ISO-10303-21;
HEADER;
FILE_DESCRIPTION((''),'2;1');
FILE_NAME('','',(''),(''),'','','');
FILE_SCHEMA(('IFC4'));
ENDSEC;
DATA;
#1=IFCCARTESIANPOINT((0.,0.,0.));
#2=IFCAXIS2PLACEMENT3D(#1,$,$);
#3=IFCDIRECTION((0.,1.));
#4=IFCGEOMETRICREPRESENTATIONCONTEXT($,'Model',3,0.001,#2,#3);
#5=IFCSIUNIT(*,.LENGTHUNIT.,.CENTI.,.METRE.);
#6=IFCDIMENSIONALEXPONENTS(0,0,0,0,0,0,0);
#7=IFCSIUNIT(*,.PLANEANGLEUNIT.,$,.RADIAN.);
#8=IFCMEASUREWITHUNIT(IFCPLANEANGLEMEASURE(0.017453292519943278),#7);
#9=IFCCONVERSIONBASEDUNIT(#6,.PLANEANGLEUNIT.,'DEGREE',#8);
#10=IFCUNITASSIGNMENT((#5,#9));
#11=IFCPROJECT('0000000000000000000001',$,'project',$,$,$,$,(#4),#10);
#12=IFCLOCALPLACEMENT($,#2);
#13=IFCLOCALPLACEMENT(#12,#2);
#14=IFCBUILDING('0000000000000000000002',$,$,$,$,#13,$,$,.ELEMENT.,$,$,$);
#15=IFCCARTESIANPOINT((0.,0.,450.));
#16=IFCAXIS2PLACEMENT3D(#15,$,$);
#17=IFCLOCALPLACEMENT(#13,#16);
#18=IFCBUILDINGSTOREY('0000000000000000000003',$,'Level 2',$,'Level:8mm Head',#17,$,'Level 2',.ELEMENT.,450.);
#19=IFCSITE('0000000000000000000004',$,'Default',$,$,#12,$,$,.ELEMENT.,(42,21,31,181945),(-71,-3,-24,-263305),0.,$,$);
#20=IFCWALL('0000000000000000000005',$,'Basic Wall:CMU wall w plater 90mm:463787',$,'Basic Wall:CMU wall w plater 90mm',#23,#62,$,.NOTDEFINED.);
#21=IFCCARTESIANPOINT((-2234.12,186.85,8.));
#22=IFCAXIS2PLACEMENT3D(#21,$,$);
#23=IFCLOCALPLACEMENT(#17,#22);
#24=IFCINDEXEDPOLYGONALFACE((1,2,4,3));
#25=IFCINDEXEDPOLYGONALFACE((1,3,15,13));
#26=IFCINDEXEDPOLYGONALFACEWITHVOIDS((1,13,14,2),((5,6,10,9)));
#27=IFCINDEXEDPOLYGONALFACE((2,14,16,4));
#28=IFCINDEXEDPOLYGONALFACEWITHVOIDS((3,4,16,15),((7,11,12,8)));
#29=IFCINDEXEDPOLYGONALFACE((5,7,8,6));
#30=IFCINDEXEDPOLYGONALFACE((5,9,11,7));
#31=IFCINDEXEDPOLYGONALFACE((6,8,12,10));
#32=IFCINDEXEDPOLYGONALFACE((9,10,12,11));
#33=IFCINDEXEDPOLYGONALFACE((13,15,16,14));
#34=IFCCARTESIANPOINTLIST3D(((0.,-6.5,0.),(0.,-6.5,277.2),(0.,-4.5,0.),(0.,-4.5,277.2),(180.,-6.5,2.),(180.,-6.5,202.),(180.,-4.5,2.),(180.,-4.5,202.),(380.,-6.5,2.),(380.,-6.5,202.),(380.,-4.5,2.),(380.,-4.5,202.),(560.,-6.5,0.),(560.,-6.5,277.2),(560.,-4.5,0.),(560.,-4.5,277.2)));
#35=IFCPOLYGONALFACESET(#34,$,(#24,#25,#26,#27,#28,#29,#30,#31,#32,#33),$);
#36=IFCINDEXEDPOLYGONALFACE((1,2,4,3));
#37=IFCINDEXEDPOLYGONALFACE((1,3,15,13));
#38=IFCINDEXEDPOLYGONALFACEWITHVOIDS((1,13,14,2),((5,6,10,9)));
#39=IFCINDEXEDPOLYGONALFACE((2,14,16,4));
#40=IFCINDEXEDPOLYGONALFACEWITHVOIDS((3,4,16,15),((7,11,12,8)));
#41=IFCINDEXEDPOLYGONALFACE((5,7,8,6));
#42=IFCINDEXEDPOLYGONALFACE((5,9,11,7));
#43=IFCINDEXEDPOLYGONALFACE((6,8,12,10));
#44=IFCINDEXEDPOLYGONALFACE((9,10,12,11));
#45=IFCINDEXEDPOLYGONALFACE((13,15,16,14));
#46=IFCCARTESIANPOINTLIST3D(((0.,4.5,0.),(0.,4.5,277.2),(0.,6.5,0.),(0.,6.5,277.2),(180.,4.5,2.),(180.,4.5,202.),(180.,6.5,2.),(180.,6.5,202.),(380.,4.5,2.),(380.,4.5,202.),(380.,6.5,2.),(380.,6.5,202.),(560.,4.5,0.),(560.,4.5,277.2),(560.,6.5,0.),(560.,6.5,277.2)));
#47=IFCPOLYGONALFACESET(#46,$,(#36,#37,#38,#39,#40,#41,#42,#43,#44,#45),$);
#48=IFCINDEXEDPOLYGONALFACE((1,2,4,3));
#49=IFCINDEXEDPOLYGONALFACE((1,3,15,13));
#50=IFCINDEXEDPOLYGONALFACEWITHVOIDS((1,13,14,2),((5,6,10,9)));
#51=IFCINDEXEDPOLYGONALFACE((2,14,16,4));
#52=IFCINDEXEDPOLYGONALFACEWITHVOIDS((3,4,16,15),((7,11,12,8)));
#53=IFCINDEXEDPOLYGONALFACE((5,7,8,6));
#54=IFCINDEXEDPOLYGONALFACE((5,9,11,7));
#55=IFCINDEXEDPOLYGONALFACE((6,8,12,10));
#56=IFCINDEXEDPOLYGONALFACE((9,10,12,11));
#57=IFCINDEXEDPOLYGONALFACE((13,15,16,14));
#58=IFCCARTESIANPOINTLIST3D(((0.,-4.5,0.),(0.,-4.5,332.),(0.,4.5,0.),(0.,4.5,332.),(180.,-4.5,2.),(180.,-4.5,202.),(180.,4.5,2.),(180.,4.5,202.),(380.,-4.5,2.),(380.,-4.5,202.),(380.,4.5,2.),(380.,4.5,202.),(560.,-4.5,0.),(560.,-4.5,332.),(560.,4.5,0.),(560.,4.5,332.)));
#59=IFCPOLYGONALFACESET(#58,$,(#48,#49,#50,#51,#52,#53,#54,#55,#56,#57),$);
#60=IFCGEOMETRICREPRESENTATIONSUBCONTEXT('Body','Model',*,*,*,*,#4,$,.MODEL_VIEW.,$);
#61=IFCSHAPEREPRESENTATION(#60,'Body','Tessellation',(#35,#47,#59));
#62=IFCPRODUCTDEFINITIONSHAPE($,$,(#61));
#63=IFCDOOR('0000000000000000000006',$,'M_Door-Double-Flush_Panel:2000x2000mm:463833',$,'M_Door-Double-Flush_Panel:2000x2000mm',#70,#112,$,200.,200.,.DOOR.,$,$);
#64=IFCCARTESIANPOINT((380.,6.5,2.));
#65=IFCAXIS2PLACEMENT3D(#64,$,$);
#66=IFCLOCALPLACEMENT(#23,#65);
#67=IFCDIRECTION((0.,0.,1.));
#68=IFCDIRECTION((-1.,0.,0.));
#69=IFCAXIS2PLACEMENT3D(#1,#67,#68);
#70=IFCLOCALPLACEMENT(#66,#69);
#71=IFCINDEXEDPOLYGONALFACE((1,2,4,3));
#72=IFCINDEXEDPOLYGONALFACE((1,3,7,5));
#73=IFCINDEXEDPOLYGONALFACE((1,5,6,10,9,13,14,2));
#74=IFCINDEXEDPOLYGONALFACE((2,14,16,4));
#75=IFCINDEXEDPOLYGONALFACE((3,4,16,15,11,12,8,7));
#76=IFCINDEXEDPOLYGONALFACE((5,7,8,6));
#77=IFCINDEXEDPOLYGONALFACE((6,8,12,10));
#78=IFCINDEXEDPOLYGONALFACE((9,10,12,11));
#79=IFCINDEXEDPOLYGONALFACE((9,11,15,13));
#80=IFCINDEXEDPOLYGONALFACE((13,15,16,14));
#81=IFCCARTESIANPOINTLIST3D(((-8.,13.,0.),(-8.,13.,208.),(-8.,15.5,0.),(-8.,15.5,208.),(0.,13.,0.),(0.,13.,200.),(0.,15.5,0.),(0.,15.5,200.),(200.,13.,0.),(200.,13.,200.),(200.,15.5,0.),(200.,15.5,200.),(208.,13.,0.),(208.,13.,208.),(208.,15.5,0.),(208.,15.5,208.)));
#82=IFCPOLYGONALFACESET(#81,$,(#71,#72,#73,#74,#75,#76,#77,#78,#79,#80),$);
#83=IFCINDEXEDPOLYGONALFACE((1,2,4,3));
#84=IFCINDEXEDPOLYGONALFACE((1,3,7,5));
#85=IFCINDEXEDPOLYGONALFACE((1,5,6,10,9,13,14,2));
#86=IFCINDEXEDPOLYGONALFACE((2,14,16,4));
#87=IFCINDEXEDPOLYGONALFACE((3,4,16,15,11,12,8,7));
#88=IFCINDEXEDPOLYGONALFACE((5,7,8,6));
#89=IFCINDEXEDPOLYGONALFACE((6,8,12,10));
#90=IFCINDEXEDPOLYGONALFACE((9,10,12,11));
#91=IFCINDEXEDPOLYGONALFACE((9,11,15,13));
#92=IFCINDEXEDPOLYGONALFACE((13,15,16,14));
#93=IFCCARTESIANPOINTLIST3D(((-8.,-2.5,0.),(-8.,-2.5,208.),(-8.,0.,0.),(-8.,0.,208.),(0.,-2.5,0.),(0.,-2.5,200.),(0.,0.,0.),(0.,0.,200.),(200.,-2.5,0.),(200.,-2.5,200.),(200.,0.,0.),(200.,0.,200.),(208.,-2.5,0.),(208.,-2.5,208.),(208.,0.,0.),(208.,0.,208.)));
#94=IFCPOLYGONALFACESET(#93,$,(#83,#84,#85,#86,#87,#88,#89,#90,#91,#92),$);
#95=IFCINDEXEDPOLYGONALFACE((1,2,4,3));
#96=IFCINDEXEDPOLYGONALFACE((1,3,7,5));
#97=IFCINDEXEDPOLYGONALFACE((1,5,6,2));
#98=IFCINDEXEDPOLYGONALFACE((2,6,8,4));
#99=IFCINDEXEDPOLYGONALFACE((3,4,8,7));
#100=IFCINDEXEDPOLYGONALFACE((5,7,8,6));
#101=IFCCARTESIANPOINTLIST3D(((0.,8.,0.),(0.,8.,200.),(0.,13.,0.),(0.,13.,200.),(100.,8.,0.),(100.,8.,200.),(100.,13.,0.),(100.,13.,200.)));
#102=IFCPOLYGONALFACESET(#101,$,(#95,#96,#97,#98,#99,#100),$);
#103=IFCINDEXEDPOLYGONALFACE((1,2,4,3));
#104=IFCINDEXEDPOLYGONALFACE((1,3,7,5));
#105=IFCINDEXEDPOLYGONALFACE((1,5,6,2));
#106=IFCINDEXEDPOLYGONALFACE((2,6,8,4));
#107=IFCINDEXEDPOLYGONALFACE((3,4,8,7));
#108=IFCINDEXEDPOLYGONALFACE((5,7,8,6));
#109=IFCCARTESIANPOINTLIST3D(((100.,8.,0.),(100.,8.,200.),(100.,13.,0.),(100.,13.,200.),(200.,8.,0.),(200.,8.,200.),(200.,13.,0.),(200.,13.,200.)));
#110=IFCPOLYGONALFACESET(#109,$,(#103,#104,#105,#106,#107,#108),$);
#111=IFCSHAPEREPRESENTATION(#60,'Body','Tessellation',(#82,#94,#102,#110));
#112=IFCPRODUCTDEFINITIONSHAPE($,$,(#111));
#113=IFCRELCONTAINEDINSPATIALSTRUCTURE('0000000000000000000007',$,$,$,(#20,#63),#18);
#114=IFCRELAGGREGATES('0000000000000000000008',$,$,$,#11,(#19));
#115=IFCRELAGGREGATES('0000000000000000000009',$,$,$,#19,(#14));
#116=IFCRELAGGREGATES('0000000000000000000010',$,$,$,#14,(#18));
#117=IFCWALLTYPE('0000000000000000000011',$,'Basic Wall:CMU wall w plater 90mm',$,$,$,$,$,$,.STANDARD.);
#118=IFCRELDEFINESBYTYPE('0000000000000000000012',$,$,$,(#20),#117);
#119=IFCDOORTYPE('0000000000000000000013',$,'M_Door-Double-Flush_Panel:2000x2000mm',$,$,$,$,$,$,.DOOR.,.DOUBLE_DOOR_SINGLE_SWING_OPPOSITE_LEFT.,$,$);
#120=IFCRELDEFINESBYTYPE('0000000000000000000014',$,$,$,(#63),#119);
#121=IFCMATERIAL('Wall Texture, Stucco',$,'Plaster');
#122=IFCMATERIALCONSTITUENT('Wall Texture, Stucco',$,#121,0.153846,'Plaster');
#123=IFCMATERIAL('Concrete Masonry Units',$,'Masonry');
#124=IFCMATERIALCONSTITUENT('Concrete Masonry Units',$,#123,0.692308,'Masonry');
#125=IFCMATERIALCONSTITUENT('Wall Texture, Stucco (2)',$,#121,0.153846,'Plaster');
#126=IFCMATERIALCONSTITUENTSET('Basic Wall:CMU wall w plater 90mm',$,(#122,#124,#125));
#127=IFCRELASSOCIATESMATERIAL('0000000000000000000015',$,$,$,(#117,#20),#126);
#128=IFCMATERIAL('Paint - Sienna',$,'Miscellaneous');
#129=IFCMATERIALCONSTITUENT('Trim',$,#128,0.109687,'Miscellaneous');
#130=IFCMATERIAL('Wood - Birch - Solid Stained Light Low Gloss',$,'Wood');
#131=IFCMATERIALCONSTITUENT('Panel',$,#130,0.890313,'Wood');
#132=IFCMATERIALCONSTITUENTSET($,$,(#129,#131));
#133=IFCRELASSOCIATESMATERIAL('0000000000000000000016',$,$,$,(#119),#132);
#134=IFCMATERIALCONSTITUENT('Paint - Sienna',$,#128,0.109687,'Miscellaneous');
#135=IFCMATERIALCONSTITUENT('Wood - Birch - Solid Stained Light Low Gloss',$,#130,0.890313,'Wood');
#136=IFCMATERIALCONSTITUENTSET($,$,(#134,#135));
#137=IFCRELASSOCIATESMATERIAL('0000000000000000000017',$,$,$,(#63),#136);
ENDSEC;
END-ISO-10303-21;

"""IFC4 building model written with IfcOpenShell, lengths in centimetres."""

from ifc_helpers import new_model, entity, si_unit, converted_unit, direction, frame, origin, place, context, subcontext, project, spatial, indexed_curve, outline, extrude, source, transform, mapped, material, constituent, constituent_set, type_object, type_shapes, element, fill, save


model = new_model("IFC4")

# Units and contexts
model_context = context("Model", 3, precision=0.001, world=origin(), true_north=direction((0.0, 1.0)))
body_context = subcontext(model_context, "Body", "Model", "MODEL_VIEW")
ifc_project = project(units=[si_unit("LENGTHUNIT", "METRE", prefix="CENTI"), converted_unit("PLANEANGLEUNIT", "DEGREE", entity("IfcPlaneAngleMeasure", 0.017453292519943278), si_unit("PLANEANGLEUNIT", "RADIAN"), dimensions=[0, 0, 0, 0, 0, 0, 0])], contexts=[model_context])

# Site, building, storey
site_placement = place(None, origin())
site = spatial("IfcSite", under=ifc_project, at=site_placement, Name="Default", CompositionType="ELEMENT", RefLatitude=(42, 21, 31, 181945), RefLongitude=(-71, -3, -24, -263305), RefElevation=0.0)
building_placement = place(site_placement, origin())
building = spatial("IfcBuilding", under=site, at=building_placement, CompositionType="ELEMENT")
storey_placement = place(building_placement, frame((0.0, 0.0, 450.0)))
storey = spatial("IfcBuildingStorey", under=building, at=storey_placement, Name="Level 2", ObjectType="Level:8mm Head", LongName="Level 2", CompositionType="ELEMENT", Elevation=450.0)

# Shared definitions
ifc_material_1 = material(Name="Concrete Masonry Units", Category="Masonry")

# Wall, opening, door
ifc_material_2 = material(Name="Wall Texture, Stucco", Category="Plaster")
ifc_constituent_1 = constituent(ifc_material_2, Name="Wall Texture, Stucco", Category="Plaster", fraction=0.153846)
ifc_constituent_2 = constituent(ifc_material_1, Name="Concrete Masonry Units", Category="Masonry", fraction=0.692308)
ifc_constituent_3 = constituent(ifc_material_2, Name="Wall Texture, Stucco (2)", Category="Plaster", fraction=0.153846)
ifc_constituent_set_1 = constituent_set(constituents=[ifc_constituent_1, ifc_constituent_2, ifc_constituent_3], Name="Basic Wall:CMU wall w plater 90mm")
wall_type_1 = type_object("IfcWallType", Name="Basic Wall:CMU wall w plater 90mm", PredefinedType="STANDARD", material=ifc_constituent_set_1)
wall_1_placement = place(storey_placement, frame((-2234.12, 186.85, 8.0)))
wall_1 = element("IfcWall", 1, at=wall_1_placement, inside=storey, type_object=wall_type_1, material=ifc_constituent_set_1, Name="Basic Wall:CMU wall w plater 90mm:463787", ObjectType="Basic Wall:CMU wall w plater 90mm", PredefinedType="NOTDEFINED", context=body_context, shape_type="SweptSolid", body=[
    extrude(outline(indexed_curve([(-138.6, -280.0), (138.6, -280.0), (138.6, -278.0), (138.6, 278.0), (138.6, 280.0), (-138.6, 280.0), (-138.6, 278.0), (-138.6, -278.0), (-138.6, -280.0)], self_intersect=False), holes=[indexed_curve([(-136.6, -100.0), (-136.6, 100.0), (63.4, 100.0), (63.4, -100.0), (-136.6, -100.0)], self_intersect=False)]), frame((280.0, -6.5, 138.6), z_axis=(0.0, 1.0, 0.0), x_axis=(0.0, 0.0, 1.0)), (0.0, 0.0, 1.0), 2.0),
    extrude(outline(indexed_curve([(-138.6, -280.0), (138.6, -280.0), (138.6, 280.0), (-138.6, 280.0), (-138.6, -280.0)], self_intersect=False), holes=[indexed_curve([(-136.6, -100.0), (-136.6, 100.0), (63.4, 100.0), (63.4, -100.0), (-136.6, -100.0)], self_intersect=False)]), frame((280.0, 4.5, 138.6), z_axis=(0.0, 1.0, 0.0), x_axis=(0.0, 0.0, 1.0)), (0.0, 0.0, 1.0), 2.0),
    extrude(outline(indexed_curve([(-203.07, -280.0), (74.13, -280.0), (128.93, -280.0), (128.93, 280.0), (74.13, 280.0), (-203.07, 280.0), (-203.07, -280.0)], self_intersect=False), holes=[indexed_curve([(-201.07, -100.0), (-201.07, 100.0), (-1.07, 100.0), (-1.07, -100.0), (-201.07, -100.0)], self_intersect=False)]), frame((280.0, -4.5, 203.07), z_axis=(0.0, 1.0, 0.0), x_axis=(0.0, 0.0, 1.0)), (0.0, 0.0, 1.0), 9.0),
])
opening_1_placement = place(wall_1_placement, frame((380.0, 6.5, 2.0)))
opening_1 = element("IfcOpeningElement", 2, at=opening_1_placement, cuts=wall_1, PredefinedType="OPENING", context=body_context, shape_type="SweptSolid", body=[
    extrude(outline(indexed_curve([(0.0, 200.0), (0.0, 0.0), (200.0, 0.0), (200.0, 200.0), (0.0, 200.0)], self_intersect=False)), frame((0.0, 0.0, 0.0), z_axis=(0.0, -1.0, 0.0), x_axis=(0.0, 0.0, 1.0)), (0.0, 0.0, 1.0), 13.0),
])
ifc_material_3 = material(Name="Paint - Sienna", Category="Miscellaneous")
ifc_constituent_4 = constituent(ifc_material_3, Name="Paint - Sienna", Category="Miscellaneous", fraction=0.109687)
ifc_material_4 = material(Name="Wood - Birch - Solid Stained Light Low Gloss", Category="Wood")
ifc_constituent_5 = constituent(ifc_material_4, Name="Wood - Birch - Solid Stained Light Low Gloss", Category="Wood", fraction=0.890313)
ifc_constituent_set_2 = constituent_set(constituents=[ifc_constituent_4, ifc_constituent_5])
ifc_constituent_6 = constituent(ifc_material_3, Name="Trim", Category="Miscellaneous", fraction=0.109687)
ifc_constituent_7 = constituent(ifc_material_4, Name="Panel", Category="Wood", fraction=0.890313)
ifc_constituent_set_3 = constituent_set(constituents=[ifc_constituent_6, ifc_constituent_7])
door_type = type_object("IfcDoorType", Name="M_Door-Double-Flush_Panel:2000x2000mm", OperationType="DOUBLE_DOOR_SINGLE_SWING_OPPOSITE_LEFT", PredefinedType="DOOR", material=ifc_constituent_set_3)
shared_shape_1 = source(origin(), body_context, "Body", "SweptSolid", [
    extrude(outline(indexed_curve([(-98.0, 100.0), (102.0, 100.0), (102.0, 108.0), (-106.0, 108.0), (-106.0, -108.0), (102.0, -108.0), (102.0, -100.0), (-98.0, -100.0), (-98.0, 100.0)], self_intersect=False)), frame((100.0, 13.0, 102.0), z_axis=(0.0, 1.0, 0.0), x_axis=(0.0, 0.0, -1.0)), (0.0, 0.0, 1.0), 2.5),
    extrude(outline(indexed_curve([(-98.0, 100.0), (102.0, 100.0), (102.0, 108.0), (-106.0, 108.0), (-106.0, -108.0), (102.0, -108.0), (102.0, -100.0), (-98.0, -100.0), (-98.0, 100.0)], self_intersect=False)), frame((100.0, -2.5, 102.0), z_axis=(0.0, 1.0, 0.0), x_axis=(0.0, 0.0, -1.0)), (0.0, 0.0, 1.0), 2.5),
    extrude(outline(indexed_curve([(-2.5, -50.0), (2.5, -50.0), (2.5, 50.0), (-2.5, 50.0), (-2.5, -50.0)], self_intersect=False)), frame((50.0, 10.5, 0.0), z_axis=(0.0, 0.0, 1.0), x_axis=(0.0, -1.0, 0.0)), (0.0, 0.0, 1.0), 200.0),
    extrude(outline(indexed_curve([(-2.5, -50.0), (2.5, -50.0), (2.5, 50.0), (-2.5, 50.0), (-2.5, -50.0)], self_intersect=False)), frame((150.0, 10.5, 0.0), z_axis=(0.0, 0.0, 1.0), x_axis=(0.0, -1.0, 0.0)), (0.0, 0.0, 1.0), 200.0),
])
type_shapes(door_type, [shared_shape_1])
door_placement = place(opening_1_placement, frame((0.0, 0.0, 0.0), z_axis=(0.0, 0.0, 1.0), x_axis=(-1.0, 0.0, 0.0)))
door = element("IfcDoor", 3, at=door_placement, inside=storey, type_object=door_type, material=ifc_constituent_set_2, Name="M_Door-Double-Flush_Panel:2000x2000mm:463833", ObjectType="M_Door-Double-Flush_Panel:2000x2000mm", OverallHeight=200.0, OverallWidth=200.0, PredefinedType="DOOR", context=body_context, shape_type="MappedRepresentation", body=[
    mapped(shared_shape_1, transform((0.0, 0.0, 0.0), scale=1.0)),
])
fill(opening_1, door)

save(model, "model.ifc")
